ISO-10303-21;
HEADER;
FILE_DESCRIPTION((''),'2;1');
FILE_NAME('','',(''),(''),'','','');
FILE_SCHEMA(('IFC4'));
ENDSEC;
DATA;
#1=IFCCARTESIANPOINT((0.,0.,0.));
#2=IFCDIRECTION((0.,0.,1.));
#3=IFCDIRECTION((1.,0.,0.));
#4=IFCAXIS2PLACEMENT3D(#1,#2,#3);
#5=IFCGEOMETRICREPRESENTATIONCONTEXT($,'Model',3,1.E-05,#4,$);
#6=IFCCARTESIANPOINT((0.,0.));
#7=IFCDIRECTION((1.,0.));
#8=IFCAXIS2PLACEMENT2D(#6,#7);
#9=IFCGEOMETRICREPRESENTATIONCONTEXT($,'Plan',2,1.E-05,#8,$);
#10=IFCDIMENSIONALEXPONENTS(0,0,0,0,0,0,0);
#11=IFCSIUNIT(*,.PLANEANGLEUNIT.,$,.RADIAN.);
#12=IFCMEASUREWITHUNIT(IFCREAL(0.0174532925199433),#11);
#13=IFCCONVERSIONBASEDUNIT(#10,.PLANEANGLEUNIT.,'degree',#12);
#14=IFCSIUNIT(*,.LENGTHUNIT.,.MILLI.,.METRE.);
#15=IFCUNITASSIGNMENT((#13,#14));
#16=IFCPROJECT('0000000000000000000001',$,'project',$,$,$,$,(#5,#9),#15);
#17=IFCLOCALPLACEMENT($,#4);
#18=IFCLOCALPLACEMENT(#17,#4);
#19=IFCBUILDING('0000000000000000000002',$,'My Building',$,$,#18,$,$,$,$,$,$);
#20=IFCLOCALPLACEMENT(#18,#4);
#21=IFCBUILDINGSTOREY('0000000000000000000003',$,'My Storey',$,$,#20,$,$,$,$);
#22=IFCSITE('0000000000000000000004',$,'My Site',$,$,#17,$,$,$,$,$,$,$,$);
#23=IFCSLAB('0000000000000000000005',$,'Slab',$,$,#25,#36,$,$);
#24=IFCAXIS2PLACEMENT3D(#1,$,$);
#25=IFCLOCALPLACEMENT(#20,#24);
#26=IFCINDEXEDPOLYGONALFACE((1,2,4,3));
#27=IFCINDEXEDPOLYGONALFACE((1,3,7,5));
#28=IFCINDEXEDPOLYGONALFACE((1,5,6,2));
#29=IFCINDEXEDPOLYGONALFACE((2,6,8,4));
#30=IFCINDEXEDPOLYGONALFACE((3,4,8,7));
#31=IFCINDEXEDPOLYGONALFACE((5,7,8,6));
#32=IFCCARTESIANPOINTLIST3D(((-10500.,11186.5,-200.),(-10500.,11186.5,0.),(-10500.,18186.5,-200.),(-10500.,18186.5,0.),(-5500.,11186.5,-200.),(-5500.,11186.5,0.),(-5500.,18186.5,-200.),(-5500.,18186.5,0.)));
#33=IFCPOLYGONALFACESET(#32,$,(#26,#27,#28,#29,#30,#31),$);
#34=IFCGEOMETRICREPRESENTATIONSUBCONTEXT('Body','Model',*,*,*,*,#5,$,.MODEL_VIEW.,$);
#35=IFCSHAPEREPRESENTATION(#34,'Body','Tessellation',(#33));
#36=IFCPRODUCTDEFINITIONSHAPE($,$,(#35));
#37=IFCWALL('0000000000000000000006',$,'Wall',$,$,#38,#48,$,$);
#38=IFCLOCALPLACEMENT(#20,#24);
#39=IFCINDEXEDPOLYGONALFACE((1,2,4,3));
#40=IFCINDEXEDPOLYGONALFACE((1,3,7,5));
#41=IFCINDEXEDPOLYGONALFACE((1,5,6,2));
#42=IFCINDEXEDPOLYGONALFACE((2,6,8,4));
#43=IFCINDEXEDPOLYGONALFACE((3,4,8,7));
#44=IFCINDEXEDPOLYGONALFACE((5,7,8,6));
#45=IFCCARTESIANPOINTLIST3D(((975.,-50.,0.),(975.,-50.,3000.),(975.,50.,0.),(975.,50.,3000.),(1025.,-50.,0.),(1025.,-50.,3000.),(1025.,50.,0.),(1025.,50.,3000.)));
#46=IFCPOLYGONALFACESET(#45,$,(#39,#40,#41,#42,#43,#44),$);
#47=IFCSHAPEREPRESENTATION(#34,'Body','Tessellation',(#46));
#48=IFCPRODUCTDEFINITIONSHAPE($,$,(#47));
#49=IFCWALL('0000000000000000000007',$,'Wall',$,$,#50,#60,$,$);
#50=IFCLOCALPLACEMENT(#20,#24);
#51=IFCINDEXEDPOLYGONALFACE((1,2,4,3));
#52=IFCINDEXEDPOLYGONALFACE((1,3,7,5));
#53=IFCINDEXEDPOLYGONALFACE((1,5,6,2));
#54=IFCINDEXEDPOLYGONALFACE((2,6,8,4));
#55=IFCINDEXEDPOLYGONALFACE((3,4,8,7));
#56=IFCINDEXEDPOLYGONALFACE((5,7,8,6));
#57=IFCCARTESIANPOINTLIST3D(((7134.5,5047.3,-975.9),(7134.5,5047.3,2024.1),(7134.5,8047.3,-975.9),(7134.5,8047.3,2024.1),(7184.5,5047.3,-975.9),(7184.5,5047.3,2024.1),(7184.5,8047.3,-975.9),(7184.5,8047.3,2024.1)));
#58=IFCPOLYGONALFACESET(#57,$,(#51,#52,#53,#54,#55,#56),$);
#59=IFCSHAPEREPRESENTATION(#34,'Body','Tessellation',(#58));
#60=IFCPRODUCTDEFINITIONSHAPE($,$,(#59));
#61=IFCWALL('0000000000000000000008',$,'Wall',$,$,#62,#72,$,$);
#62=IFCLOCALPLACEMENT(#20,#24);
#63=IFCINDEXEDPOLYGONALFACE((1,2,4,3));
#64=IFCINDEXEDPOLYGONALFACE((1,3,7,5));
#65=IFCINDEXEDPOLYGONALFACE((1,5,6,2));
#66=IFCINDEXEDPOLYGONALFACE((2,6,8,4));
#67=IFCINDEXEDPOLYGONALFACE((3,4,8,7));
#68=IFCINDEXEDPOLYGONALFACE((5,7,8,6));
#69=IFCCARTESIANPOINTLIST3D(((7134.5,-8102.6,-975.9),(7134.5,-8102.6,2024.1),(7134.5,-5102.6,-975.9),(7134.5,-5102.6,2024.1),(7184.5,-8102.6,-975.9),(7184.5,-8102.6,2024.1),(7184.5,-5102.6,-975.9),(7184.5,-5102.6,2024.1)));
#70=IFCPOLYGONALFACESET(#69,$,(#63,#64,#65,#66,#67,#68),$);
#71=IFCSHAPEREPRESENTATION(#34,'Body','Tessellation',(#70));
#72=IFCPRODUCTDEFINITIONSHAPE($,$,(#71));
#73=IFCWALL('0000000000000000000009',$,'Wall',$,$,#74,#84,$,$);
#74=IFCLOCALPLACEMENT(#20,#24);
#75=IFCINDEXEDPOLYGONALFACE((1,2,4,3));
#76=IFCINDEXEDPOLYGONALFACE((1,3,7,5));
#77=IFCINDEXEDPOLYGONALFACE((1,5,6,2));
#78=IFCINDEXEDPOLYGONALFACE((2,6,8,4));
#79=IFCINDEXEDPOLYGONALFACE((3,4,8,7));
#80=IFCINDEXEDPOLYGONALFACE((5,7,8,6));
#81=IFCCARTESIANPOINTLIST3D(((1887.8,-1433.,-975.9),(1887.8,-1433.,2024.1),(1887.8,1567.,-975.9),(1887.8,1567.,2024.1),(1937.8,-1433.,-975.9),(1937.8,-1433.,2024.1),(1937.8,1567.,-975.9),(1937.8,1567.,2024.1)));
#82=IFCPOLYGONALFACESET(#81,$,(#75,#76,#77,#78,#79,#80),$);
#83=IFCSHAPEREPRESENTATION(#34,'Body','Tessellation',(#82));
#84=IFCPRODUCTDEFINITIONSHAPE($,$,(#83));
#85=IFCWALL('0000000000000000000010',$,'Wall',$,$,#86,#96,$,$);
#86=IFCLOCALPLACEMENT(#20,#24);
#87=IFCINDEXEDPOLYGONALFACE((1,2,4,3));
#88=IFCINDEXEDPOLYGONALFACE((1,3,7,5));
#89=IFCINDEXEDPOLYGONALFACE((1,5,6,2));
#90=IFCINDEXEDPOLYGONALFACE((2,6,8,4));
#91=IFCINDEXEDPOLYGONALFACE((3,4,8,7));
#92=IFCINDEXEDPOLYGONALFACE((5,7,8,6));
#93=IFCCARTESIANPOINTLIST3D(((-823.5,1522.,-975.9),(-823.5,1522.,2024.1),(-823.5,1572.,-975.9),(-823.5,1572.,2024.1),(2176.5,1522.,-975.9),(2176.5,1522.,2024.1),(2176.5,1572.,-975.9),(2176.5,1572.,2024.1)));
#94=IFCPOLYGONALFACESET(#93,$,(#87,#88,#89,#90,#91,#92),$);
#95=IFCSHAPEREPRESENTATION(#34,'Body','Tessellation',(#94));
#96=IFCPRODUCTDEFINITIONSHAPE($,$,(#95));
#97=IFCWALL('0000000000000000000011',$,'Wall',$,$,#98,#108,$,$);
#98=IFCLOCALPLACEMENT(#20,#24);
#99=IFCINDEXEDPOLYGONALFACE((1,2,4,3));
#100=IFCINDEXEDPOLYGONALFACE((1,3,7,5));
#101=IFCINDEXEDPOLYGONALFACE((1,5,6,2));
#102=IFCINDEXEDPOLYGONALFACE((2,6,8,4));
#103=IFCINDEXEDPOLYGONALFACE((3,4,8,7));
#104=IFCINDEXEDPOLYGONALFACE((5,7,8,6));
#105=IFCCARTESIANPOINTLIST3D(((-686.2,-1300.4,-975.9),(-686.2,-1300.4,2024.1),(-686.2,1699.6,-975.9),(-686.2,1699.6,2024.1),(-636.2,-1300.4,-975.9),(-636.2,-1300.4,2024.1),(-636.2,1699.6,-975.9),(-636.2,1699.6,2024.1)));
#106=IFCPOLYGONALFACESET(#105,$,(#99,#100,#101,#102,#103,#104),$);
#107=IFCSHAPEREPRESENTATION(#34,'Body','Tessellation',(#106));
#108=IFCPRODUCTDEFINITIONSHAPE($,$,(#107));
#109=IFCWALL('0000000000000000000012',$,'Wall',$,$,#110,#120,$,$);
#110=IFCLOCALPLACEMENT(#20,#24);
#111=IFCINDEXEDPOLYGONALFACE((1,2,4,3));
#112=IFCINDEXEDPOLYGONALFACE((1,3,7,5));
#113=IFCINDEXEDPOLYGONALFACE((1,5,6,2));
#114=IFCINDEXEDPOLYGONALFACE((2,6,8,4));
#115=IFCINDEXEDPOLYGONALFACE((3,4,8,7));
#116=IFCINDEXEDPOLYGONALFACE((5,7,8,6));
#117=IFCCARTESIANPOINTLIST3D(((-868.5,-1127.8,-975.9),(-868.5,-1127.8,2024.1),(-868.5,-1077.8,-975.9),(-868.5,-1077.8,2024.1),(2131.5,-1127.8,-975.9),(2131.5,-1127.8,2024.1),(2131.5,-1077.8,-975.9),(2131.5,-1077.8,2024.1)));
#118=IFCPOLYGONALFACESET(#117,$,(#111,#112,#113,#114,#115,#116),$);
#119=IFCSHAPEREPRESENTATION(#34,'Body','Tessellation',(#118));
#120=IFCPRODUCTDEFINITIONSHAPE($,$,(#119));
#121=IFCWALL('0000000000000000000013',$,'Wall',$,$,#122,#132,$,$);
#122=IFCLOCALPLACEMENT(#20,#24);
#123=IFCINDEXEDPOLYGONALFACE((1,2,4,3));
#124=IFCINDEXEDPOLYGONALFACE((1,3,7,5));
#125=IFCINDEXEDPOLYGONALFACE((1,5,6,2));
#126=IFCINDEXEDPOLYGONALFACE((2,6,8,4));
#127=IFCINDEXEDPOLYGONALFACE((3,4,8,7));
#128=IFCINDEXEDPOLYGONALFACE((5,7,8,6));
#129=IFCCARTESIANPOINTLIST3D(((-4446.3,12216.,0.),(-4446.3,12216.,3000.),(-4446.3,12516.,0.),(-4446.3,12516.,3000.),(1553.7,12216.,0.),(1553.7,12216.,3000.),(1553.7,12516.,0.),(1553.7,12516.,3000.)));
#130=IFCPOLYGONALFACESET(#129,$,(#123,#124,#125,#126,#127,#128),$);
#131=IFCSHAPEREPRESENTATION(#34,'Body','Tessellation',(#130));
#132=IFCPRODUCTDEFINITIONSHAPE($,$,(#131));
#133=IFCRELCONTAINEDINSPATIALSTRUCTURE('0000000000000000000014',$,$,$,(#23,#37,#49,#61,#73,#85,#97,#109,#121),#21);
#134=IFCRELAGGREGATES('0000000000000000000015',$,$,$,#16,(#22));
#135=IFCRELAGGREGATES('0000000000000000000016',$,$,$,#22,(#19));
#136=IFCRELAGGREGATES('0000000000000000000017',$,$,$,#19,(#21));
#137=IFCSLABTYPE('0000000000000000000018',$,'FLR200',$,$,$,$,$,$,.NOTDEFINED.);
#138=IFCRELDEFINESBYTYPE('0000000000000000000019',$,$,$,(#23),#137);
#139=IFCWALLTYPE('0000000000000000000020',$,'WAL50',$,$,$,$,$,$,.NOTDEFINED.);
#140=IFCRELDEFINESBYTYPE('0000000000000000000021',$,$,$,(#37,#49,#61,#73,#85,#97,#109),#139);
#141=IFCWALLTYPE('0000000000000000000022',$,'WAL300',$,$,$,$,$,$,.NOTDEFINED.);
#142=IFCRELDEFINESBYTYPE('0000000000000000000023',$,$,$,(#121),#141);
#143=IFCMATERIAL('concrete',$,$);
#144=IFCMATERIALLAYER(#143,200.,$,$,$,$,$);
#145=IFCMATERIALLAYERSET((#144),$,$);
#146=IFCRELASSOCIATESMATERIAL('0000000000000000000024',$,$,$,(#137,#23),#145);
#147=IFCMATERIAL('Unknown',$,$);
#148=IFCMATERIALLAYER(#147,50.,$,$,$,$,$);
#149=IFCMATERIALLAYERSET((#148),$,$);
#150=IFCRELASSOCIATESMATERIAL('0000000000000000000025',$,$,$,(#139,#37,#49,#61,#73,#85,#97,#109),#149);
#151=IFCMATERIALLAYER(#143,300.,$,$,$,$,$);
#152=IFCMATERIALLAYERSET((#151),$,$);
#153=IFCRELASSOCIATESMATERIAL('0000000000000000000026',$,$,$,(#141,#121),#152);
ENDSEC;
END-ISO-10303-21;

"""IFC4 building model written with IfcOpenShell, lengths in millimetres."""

from ifc_helpers import new_model, entity, si_unit, converted_unit, frame, origin_with_axes, origin_2d_with_axis, place, context, subcontext, project, spatial, line, indexed_curve, outline, extrude, material, layer, layer_set, layer_usage, type_object, element, save


model = new_model("IFC4")

# Units and contexts
model_context = context("Model", 3, precision=1e-05, world=origin_with_axes())
plan_context = context("Plan", 2, precision=1e-05, world=origin_2d_with_axis())
body_context = subcontext(model_context, "Body", "Model", "MODEL_VIEW")
ifc_project = project(units=[converted_unit("PLANEANGLEUNIT", "degree", entity("IfcReal", 0.0174532925199433), si_unit("PLANEANGLEUNIT", "RADIAN"), dimensions=[0, 0, 0, 0, 0, 0, 0]), si_unit("LENGTHUNIT", "METRE", prefix="MILLI")], contexts=[model_context, plan_context])

# Site, building, storey
site_placement = place(None, origin_with_axes())
site = spatial("IfcSite", under=ifc_project, at=site_placement, Name="My Site")
building_placement = place(site_placement, origin_with_axes())
building = spatial("IfcBuilding", under=site, at=building_placement, Name="My Building")
storey_placement = place(building_placement, origin_with_axes())
storey = spatial("IfcBuildingStorey", under=building, at=storey_placement, Name="My Storey")

# Slab
ifc_material_1 = material(Name="concrete")
ifc_layer_1 = layer(ifc_material_1, 200.0)
ifc_layer_set_1 = layer_set([ifc_layer_1])
ifc_layer_usage_1 = layer_usage(ifc_layer_set_1, "AXIS3", "POSITIVE", -200.0)
slab_type = type_object("IfcSlabType", Name="FLR200", PredefinedType="NOTDEFINED", material=ifc_layer_set_1)
slab_placement = place(storey_placement, frame((-10500.0, 18186.5, 0.0), z_axis=(0.0, 0.0, 1.0), x_axis=(1.0, 0.0, 0.0)))
element("IfcSlab", 1, at=slab_placement, inside=storey, type_object=slab_type, material=ifc_layer_usage_1, Name="Slab", context=body_context, shape_type="SweptSolid", body=[
    extrude(outline(indexed_curve([(0.0, 0.0), (5000.0, 0.0), (5000.0, -7000.0), (0.0, -7000.0), (0.0, 0.0)])), frame((0.0, 0.0, -200.0), z_axis=(0.0, 0.0, 1.0), x_axis=(1.0, 0.0, 0.0)), (0.0, 0.0, 1.0), 200.0),
])

# Walls
ifc_material_2 = material(Name="Unknown")
ifc_layer_2 = layer(ifc_material_2, 50.0)
ifc_layer_set_2 = layer_set([ifc_layer_2])
ifc_layer_usage_2 = layer_usage(ifc_layer_set_2, "AXIS2", "POSITIVE", 0.0)
wall_type_1 = type_object("IfcWallType", Name="WAL50", PredefinedType="NOTDEFINED", material=ifc_layer_set_2)
wall_1_placement = place(storey_placement, frame((1025.0, -50.0, 0.0), z_axis=(0.0, 0.0, 1.0), x_axis=(0.0, 1.0, 0.0)))
element("IfcWall", 2, at=wall_1_placement, inside=storey, type_object=wall_type_1, material=ifc_layer_usage_2, Name="Wall", context=body_context, shape_type="SweptSolid", body=[
    extrude(outline(indexed_curve([(0.0, 0.0), (0.0, 50.0), (100.0, 50.0), (100.0, 0.0)], segments=[line(1, 2, 3, 4, 1)])), origin_with_axes(), (0.0, 0.0, 1.0), 3000.0),
])
ifc_layer_usage_3 = layer_usage(ifc_layer_set_2, "AXIS2", "POSITIVE", 0.0)
wall_2_placement = place(storey_placement, frame((7184.5, 5047.3, -975.9), z_axis=(0.0, 0.0, 1.0), x_axis=(0.0, 1.0, 0.0)))
element("IfcWall", 3, at=wall_2_placement, inside=storey, type_object=wall_type_1, material=ifc_layer_usage_3, Name="Wall", context=body_context, shape_type="SweptSolid", body=[
    extrude(outline(indexed_curve([(0.0, 0.0), (0.0, 50.0), (3000.0, 50.0), (3000.0, 0.0)], segments=[line(1, 2, 3, 4, 1)])), origin_with_axes(), (0.0, 0.0, 1.0), 3000.0),
])
ifc_layer_usage_4 = layer_usage(ifc_layer_set_2, "AXIS2", "POSITIVE", 0.0)
wall_3_placement = place(storey_placement, frame((7184.5, -8102.6, -975.9), z_axis=(0.0, 0.0, 1.0), x_axis=(0.0, 1.0, 0.0)))
element("IfcWall", 4, at=wall_3_placement, inside=storey, type_object=wall_type_1, material=ifc_layer_usage_4, Name="Wall", context=body_context, shape_type="SweptSolid", body=[
    extrude(outline(indexed_curve([(0.0, 0.0), (0.0, 50.0), (3000.0, 50.0), (3000.0, 0.0)], segments=[line(1, 2, 3, 4, 1)])), origin_with_axes(), (0.0, 0.0, 1.0), 3000.0),
])
ifc_layer_usage_5 = layer_usage(ifc_layer_set_2, "AXIS2", "POSITIVE", 0.0)
wall_4_placement = place(storey_placement, frame((1937.8, -1433.0, -975.9), z_axis=(0.0, 0.0, 1.0), x_axis=(0.0, 1.0, 0.0)))
element("IfcWall", 5, at=wall_4_placement, inside=storey, type_object=wall_type_1, material=ifc_layer_usage_5, Name="Wall", context=body_context, shape_type="SweptSolid", body=[
    extrude(outline(indexed_curve([(0.0, 0.0), (0.0, 50.0), (3000.0, 50.0), (3000.0, 0.0)], segments=[line(1, 2, 3, 4, 1)])), origin_with_axes(), (0.0, 0.0, 1.0), 3000.0),
])
ifc_layer_usage_6 = layer_usage(ifc_layer_set_2, "AXIS2", "POSITIVE", 0.0)
wall_5_placement = place(storey_placement, frame((-823.5, 1522.0, -975.9), z_axis=(0.0, 0.0, 1.0), x_axis=(1.0, 0.0, 0.0)))
element("IfcWall", 6, at=wall_5_placement, inside=storey, type_object=wall_type_1, material=ifc_layer_usage_6, Name="Wall", context=body_context, shape_type="SweptSolid", body=[
    extrude(outline(indexed_curve([(0.0, 0.0), (0.0, 50.0), (3000.0, 50.0), (3000.0, 0.0)], segments=[line(1, 2, 3, 4, 1)])), origin_with_axes(), (0.0, 0.0, 1.0), 3000.0),
])
ifc_layer_usage_7 = layer_usage(ifc_layer_set_2, "AXIS2", "POSITIVE", 0.0)
wall_6_placement = place(storey_placement, frame((-686.2, 1699.6, -975.9), z_axis=(0.0, 0.0, 1.0), x_axis=(0.0, -1.0, 0.0)))
element("IfcWall", 7, at=wall_6_placement, inside=storey, type_object=wall_type_1, material=ifc_layer_usage_7, Name="Wall", context=body_context, shape_type="SweptSolid", body=[
    extrude(outline(indexed_curve([(0.0, 0.0), (0.0, 50.0), (3000.0, 50.0), (3000.0, 0.0)], segments=[line(1, 2, 3, 4, 1)])), origin_with_axes(), (0.0, 0.0, 1.0), 3000.0),
])
ifc_layer_usage_8 = layer_usage(ifc_layer_set_2, "AXIS2", "POSITIVE", 0.0)
wall_7_placement = place(storey_placement, frame((2131.5, -1077.8, -975.9), z_axis=(0.0, 0.0, 1.0), x_axis=(-1.0, 0.000001, 0.0)))
element("IfcWall", 8, at=wall_7_placement, inside=storey, type_object=wall_type_1, material=ifc_layer_usage_8, Name="Wall", context=body_context, shape_type="SweptSolid", body=[
    extrude(outline(indexed_curve([(0.0, 0.0), (0.0, 50.0), (3000.0, 50.0), (3000.0, 0.0)], segments=[line(1, 2, 3, 4, 1)])), origin_with_axes(), (0.0, 0.0, 1.0), 3000.0),
])
ifc_layer_3 = layer(ifc_material_1, 300.0)
ifc_layer_set_3 = layer_set([ifc_layer_3])
ifc_layer_usage_9 = layer_usage(ifc_layer_set_3, "AXIS2", "POSITIVE", 0.0)
wall_type_2 = type_object("IfcWallType", Name="WAL300", PredefinedType="NOTDEFINED", material=ifc_layer_set_3)
wall_8_placement = place(storey_placement, frame((-4446.3, 12216.0, 0.0), z_axis=(0.0, 0.0, 1.0), x_axis=(1.0, 0.0, 0.0)))
element("IfcWall", 9, at=wall_8_placement, inside=storey, type_object=wall_type_2, material=ifc_layer_usage_9, Name="Wall", context=body_context, shape_type="SweptSolid", body=[
    extrude(outline(indexed_curve([(0.0, 0.0), (0.0, 300.0), (6000.0, 300.0), (6000.0, 0.0)], segments=[line(1, 2, 3, 4, 1)])), origin_with_axes(), (0.0, 0.0, 1.0), 3000.0),
])

save(model, "model.ifc")
